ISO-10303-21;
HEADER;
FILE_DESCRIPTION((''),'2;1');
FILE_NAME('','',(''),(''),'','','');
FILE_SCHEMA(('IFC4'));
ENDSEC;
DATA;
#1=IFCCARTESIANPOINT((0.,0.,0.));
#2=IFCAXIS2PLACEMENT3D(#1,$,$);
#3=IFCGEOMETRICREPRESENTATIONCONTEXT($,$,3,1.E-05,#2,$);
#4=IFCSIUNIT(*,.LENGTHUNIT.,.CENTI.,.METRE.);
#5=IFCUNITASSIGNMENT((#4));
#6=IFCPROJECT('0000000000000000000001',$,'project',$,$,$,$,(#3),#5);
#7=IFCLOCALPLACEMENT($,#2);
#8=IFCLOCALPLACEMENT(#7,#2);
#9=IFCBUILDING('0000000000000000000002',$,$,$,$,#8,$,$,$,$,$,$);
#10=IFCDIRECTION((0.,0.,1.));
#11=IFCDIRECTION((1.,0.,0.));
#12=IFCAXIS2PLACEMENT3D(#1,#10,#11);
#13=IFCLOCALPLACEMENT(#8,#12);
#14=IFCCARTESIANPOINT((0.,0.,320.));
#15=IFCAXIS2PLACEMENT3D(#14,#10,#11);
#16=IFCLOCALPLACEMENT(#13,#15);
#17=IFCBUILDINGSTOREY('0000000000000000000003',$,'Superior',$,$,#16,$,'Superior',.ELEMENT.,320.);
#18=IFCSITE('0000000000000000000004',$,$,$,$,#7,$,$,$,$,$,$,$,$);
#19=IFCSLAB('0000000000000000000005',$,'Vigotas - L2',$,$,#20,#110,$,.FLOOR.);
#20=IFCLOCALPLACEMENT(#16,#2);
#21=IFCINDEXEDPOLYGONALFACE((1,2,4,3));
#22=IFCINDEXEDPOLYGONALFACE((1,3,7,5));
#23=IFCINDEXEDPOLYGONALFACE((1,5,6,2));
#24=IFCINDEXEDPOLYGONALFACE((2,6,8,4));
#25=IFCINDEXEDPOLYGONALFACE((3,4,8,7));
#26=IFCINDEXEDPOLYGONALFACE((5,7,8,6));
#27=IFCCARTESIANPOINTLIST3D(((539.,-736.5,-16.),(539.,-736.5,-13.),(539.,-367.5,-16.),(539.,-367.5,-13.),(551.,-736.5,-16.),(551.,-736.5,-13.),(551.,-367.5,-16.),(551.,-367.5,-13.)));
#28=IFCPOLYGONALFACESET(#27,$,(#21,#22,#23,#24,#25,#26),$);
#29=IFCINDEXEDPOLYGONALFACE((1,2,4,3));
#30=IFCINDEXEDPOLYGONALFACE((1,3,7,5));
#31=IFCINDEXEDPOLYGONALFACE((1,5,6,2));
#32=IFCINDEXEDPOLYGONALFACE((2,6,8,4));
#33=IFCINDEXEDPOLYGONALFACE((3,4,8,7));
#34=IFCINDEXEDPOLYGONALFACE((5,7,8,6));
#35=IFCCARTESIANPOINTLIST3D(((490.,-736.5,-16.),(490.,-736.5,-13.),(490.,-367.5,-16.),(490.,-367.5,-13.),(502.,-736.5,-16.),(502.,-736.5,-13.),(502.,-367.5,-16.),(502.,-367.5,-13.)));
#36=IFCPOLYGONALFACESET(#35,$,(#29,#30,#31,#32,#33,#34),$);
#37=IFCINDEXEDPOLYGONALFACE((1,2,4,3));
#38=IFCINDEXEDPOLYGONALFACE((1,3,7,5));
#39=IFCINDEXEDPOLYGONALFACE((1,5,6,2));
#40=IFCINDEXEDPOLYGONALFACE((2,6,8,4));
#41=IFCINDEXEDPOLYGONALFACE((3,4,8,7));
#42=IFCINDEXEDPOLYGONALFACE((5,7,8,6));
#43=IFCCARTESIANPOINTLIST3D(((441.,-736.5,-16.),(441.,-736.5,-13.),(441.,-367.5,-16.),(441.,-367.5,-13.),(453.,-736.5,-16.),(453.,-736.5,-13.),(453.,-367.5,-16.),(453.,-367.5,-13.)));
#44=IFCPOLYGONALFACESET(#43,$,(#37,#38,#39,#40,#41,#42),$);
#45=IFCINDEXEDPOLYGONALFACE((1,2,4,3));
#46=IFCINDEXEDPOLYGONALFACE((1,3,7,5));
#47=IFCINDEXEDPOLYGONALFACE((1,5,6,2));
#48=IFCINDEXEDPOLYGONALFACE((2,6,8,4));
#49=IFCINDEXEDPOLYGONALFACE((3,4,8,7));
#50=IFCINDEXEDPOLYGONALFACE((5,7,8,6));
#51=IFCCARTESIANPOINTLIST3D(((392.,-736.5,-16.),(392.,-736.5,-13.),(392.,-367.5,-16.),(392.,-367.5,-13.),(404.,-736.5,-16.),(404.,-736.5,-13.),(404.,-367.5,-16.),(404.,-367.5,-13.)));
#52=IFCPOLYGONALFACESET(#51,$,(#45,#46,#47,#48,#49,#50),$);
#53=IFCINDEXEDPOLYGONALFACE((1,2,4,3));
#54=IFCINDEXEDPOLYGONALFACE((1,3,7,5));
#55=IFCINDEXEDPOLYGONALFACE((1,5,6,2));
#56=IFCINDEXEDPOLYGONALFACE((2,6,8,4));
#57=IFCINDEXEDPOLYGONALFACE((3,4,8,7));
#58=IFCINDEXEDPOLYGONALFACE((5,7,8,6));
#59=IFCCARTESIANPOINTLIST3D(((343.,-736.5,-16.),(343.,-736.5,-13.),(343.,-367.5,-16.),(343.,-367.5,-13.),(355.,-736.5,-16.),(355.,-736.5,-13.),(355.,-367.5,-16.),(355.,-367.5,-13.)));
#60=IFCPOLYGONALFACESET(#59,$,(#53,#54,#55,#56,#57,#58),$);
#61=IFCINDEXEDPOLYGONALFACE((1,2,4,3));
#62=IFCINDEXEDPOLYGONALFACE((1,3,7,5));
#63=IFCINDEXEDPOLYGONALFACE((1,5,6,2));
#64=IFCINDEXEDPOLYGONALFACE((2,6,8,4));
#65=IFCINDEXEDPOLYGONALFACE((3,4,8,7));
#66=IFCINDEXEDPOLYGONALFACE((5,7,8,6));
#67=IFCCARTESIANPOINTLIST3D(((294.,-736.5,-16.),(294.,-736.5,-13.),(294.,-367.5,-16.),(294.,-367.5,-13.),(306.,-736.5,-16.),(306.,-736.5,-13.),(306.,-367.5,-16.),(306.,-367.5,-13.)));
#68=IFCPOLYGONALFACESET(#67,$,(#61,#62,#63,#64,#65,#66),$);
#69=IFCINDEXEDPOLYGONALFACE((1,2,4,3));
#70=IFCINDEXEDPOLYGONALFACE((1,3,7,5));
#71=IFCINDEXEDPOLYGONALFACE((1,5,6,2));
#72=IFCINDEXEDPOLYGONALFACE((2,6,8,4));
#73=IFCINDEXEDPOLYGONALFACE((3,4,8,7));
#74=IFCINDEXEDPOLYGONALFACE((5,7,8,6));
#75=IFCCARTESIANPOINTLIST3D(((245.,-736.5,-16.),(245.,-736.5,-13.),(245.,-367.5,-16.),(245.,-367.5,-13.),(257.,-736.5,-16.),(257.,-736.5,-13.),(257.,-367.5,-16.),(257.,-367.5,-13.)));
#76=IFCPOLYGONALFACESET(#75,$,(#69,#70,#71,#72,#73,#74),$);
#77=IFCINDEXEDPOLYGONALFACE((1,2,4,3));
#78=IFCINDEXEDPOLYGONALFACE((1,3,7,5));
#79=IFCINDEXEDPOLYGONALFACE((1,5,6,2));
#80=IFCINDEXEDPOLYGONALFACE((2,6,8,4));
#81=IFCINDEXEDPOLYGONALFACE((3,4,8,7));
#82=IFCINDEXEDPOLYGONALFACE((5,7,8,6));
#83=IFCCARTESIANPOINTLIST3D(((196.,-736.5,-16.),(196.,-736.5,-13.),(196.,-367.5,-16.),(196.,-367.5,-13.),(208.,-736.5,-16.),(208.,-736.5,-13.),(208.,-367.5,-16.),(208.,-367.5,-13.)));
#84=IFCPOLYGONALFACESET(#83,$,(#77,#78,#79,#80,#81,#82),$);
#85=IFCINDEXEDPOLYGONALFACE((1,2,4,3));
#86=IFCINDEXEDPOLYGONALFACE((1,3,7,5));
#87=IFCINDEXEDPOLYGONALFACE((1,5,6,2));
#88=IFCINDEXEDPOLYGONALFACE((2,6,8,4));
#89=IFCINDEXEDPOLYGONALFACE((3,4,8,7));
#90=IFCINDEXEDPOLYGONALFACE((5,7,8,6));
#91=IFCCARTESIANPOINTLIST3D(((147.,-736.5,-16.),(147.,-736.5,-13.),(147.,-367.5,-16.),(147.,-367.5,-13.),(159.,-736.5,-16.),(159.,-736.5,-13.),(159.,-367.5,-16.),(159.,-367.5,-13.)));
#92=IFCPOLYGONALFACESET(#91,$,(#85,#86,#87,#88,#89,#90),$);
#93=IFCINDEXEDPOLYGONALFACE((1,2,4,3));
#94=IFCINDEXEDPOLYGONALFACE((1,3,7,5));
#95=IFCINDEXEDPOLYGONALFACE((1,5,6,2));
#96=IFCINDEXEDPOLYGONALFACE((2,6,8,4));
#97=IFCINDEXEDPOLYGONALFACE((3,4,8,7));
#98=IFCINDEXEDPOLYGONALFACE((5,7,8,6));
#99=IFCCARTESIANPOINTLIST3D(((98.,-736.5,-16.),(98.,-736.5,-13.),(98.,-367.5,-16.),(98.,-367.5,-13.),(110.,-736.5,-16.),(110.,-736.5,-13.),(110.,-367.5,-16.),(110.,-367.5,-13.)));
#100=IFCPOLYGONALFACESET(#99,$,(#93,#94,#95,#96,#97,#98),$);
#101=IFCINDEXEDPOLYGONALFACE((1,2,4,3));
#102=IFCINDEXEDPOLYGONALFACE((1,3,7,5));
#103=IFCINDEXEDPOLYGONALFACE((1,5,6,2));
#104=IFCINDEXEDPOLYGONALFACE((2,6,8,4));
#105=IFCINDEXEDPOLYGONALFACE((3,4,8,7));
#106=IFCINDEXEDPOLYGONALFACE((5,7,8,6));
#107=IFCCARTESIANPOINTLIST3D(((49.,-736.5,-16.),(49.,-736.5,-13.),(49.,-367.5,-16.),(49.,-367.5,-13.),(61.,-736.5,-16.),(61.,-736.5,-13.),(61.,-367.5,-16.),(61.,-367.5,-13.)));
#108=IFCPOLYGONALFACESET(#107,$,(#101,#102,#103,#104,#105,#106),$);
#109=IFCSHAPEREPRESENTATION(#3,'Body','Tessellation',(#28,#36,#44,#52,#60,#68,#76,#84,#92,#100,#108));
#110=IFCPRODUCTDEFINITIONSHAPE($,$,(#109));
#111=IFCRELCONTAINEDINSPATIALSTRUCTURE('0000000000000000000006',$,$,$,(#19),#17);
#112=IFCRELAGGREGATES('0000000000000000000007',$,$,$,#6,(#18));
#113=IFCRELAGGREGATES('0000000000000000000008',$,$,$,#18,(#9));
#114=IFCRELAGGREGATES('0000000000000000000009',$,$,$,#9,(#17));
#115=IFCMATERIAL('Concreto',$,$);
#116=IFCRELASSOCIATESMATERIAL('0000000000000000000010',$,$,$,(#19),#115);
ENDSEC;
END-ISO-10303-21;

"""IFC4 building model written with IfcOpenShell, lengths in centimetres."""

from ifc_helpers import new_model, si_unit, frame, origin, origin_with_axes, place, context, project, spatial, polyline, outline, extrude, material, element, save


model = new_model("IFC4")

# Units and contexts
context_of_model = context(None, 3, precision=1e-05, world=origin())
ifc_project = project(units=[si_unit("LENGTHUNIT", "METRE", prefix="CENTI")], contexts=[context_of_model])

# Site, building, storey
site_placement = place(None, origin())
site = spatial("IfcSite", under=ifc_project, at=site_placement)
building_placement = place(site_placement, origin())
building = spatial("IfcBuilding", under=site, at=building_placement)
placement = place(building_placement, origin_with_axes())
storey_placement = place(placement, frame((0.0, 0.0, 320.0), z_axis=(0.0, 0.0, 1.0), x_axis=(1.0, 0.0, 0.0)))
storey = spatial("IfcBuildingStorey", under=building, at=storey_placement, Name="Superior", LongName="Superior", CompositionType="ELEMENT", Elevation=320.0)

# Shared definitions
ifc_material = material(Name="Concreto")

# Slab
slab_1_placement = place(storey_placement, frame((300.0, -552.0, -13.0), z_axis=(0.0, 0.0, 1.0), x_axis=(1.0, 0.0, 0.0)))
element("IfcSlab", 1, at=slab_1_placement, inside=storey, material=ifc_material, Name="Vigotas - L2", PredefinedType="FLOOR", context=context_of_model, shape_type="SolidModel", body=[
    extrude(outline(polyline([(6.0, 1.5), (-6.0, 1.5), (-6.0, -1.5), (6.0, -1.5), (6.0, 1.5), (6.0, 1.5)])), frame((245.0, -184.5, -1.5), z_axis=(0.0, 1.0, 0.0), x_axis=(1.0, 0.0, 0.0)), (0.0, 0.0, 1.0), 369.0),
    extrude(outline(polyline([(6.0, 1.5), (-6.0, 1.5), (-6.0, -1.5), (6.0, -1.5), (6.0, 1.5), (6.0, 1.5)])), frame((196.0, -184.5, -1.5), z_axis=(0.0, 1.0, 0.0), x_axis=(1.0, 0.0, 0.0)), (0.0, 0.0, 1.0), 369.0),
    extrude(outline(polyline([(6.0, 1.5), (-6.0, 1.5), (-6.0, -1.5), (6.0, -1.5), (6.0, 1.5), (6.0, 1.5)])), frame((147.0, -184.5, -1.5), z_axis=(0.0, 1.0, 0.0), x_axis=(1.0, 0.0, 0.0)), (0.0, 0.0, 1.0), 369.0),
    extrude(outline(polyline([(6.0, 1.5), (-6.0, 1.5), (-6.0, -1.5), (6.0, -1.5), (6.0, 1.5), (6.0, 1.5)])), frame((98.0, -184.5, -1.5), z_axis=(0.0, 1.0, 0.0), x_axis=(1.0, 0.0, 0.0)), (0.0, 0.0, 1.0), 369.0),
    extrude(outline(polyline([(6.0, 1.5), (-6.0, 1.5), (-6.0, -1.5), (6.0, -1.5), (6.0, 1.5), (6.0, 1.5)])), frame((49.0, -184.5, -1.5), z_axis=(0.0, 1.0, 0.0), x_axis=(1.0, 0.0, 0.0)), (0.0, 0.0, 1.0), 369.0),
    extrude(outline(polyline([(6.0, 1.5), (-6.0, 1.5), (-6.0, -1.5), (6.0, -1.5), (6.0, 1.5), (6.0, 1.5)])), frame((0.0, -184.5, -1.5), z_axis=(0.0, 1.0, 0.0), x_axis=(1.0, 0.0, 0.0)), (0.0, 0.0, 1.0), 369.0),
    extrude(outline(polyline([(6.0, 1.5), (-6.0, 1.5), (-6.0, -1.5), (6.0, -1.5), (6.0, 1.5), (6.0, 1.5)])), frame((-49.0, -184.5, -1.5), z_axis=(0.0, 1.0, 0.0), x_axis=(1.0, 0.0, 0.0)), (0.0, 0.0, 1.0), 369.0),
    extrude(outline(polyline([(6.0, 1.5), (-6.0, 1.5), (-6.0, -1.5), (6.0, -1.5), (6.0, 1.5), (6.0, 1.5)])), frame((-98.0, -184.5, -1.5), z_axis=(0.0, 1.0, 0.0), x_axis=(1.0, 0.0, 0.0)), (0.0, 0.0, 1.0), 369.0),
    extrude(outline(polyline([(6.0, 1.5), (-6.0, 1.5), (-6.0, -1.5), (6.0, -1.5), (6.0, 1.5), (6.0, 1.5)])), frame((-147.0, -184.5, -1.5), z_axis=(0.0, 1.0, 0.0), x_axis=(1.0, 0.0, 0.0)), (0.0, 0.0, 1.0), 369.0),
    extrude(outline(polyline([(6.0, 1.5), (-6.0, 1.5), (-6.0, -1.5), (6.0, -1.5), (6.0, 1.5), (6.0, 1.5)])), frame((-196.0, -184.5, -1.5), z_axis=(0.0, 1.0, 0.0), x_axis=(1.0, 0.0, 0.0)), (0.0, 0.0, 1.0), 369.0),
    extrude(outline(polyline([(6.0, 1.5), (-6.0, 1.5), (-6.0, -1.5), (6.0, -1.5), (6.0, 1.5), (6.0, 1.5)])), frame((-245.0, -184.5, -1.5), z_axis=(0.0, 1.0, 0.0), x_axis=(1.0, 0.0, 0.0)), (0.0, 0.0, 1.0), 369.0),
])

save(model, "model.ifc")
